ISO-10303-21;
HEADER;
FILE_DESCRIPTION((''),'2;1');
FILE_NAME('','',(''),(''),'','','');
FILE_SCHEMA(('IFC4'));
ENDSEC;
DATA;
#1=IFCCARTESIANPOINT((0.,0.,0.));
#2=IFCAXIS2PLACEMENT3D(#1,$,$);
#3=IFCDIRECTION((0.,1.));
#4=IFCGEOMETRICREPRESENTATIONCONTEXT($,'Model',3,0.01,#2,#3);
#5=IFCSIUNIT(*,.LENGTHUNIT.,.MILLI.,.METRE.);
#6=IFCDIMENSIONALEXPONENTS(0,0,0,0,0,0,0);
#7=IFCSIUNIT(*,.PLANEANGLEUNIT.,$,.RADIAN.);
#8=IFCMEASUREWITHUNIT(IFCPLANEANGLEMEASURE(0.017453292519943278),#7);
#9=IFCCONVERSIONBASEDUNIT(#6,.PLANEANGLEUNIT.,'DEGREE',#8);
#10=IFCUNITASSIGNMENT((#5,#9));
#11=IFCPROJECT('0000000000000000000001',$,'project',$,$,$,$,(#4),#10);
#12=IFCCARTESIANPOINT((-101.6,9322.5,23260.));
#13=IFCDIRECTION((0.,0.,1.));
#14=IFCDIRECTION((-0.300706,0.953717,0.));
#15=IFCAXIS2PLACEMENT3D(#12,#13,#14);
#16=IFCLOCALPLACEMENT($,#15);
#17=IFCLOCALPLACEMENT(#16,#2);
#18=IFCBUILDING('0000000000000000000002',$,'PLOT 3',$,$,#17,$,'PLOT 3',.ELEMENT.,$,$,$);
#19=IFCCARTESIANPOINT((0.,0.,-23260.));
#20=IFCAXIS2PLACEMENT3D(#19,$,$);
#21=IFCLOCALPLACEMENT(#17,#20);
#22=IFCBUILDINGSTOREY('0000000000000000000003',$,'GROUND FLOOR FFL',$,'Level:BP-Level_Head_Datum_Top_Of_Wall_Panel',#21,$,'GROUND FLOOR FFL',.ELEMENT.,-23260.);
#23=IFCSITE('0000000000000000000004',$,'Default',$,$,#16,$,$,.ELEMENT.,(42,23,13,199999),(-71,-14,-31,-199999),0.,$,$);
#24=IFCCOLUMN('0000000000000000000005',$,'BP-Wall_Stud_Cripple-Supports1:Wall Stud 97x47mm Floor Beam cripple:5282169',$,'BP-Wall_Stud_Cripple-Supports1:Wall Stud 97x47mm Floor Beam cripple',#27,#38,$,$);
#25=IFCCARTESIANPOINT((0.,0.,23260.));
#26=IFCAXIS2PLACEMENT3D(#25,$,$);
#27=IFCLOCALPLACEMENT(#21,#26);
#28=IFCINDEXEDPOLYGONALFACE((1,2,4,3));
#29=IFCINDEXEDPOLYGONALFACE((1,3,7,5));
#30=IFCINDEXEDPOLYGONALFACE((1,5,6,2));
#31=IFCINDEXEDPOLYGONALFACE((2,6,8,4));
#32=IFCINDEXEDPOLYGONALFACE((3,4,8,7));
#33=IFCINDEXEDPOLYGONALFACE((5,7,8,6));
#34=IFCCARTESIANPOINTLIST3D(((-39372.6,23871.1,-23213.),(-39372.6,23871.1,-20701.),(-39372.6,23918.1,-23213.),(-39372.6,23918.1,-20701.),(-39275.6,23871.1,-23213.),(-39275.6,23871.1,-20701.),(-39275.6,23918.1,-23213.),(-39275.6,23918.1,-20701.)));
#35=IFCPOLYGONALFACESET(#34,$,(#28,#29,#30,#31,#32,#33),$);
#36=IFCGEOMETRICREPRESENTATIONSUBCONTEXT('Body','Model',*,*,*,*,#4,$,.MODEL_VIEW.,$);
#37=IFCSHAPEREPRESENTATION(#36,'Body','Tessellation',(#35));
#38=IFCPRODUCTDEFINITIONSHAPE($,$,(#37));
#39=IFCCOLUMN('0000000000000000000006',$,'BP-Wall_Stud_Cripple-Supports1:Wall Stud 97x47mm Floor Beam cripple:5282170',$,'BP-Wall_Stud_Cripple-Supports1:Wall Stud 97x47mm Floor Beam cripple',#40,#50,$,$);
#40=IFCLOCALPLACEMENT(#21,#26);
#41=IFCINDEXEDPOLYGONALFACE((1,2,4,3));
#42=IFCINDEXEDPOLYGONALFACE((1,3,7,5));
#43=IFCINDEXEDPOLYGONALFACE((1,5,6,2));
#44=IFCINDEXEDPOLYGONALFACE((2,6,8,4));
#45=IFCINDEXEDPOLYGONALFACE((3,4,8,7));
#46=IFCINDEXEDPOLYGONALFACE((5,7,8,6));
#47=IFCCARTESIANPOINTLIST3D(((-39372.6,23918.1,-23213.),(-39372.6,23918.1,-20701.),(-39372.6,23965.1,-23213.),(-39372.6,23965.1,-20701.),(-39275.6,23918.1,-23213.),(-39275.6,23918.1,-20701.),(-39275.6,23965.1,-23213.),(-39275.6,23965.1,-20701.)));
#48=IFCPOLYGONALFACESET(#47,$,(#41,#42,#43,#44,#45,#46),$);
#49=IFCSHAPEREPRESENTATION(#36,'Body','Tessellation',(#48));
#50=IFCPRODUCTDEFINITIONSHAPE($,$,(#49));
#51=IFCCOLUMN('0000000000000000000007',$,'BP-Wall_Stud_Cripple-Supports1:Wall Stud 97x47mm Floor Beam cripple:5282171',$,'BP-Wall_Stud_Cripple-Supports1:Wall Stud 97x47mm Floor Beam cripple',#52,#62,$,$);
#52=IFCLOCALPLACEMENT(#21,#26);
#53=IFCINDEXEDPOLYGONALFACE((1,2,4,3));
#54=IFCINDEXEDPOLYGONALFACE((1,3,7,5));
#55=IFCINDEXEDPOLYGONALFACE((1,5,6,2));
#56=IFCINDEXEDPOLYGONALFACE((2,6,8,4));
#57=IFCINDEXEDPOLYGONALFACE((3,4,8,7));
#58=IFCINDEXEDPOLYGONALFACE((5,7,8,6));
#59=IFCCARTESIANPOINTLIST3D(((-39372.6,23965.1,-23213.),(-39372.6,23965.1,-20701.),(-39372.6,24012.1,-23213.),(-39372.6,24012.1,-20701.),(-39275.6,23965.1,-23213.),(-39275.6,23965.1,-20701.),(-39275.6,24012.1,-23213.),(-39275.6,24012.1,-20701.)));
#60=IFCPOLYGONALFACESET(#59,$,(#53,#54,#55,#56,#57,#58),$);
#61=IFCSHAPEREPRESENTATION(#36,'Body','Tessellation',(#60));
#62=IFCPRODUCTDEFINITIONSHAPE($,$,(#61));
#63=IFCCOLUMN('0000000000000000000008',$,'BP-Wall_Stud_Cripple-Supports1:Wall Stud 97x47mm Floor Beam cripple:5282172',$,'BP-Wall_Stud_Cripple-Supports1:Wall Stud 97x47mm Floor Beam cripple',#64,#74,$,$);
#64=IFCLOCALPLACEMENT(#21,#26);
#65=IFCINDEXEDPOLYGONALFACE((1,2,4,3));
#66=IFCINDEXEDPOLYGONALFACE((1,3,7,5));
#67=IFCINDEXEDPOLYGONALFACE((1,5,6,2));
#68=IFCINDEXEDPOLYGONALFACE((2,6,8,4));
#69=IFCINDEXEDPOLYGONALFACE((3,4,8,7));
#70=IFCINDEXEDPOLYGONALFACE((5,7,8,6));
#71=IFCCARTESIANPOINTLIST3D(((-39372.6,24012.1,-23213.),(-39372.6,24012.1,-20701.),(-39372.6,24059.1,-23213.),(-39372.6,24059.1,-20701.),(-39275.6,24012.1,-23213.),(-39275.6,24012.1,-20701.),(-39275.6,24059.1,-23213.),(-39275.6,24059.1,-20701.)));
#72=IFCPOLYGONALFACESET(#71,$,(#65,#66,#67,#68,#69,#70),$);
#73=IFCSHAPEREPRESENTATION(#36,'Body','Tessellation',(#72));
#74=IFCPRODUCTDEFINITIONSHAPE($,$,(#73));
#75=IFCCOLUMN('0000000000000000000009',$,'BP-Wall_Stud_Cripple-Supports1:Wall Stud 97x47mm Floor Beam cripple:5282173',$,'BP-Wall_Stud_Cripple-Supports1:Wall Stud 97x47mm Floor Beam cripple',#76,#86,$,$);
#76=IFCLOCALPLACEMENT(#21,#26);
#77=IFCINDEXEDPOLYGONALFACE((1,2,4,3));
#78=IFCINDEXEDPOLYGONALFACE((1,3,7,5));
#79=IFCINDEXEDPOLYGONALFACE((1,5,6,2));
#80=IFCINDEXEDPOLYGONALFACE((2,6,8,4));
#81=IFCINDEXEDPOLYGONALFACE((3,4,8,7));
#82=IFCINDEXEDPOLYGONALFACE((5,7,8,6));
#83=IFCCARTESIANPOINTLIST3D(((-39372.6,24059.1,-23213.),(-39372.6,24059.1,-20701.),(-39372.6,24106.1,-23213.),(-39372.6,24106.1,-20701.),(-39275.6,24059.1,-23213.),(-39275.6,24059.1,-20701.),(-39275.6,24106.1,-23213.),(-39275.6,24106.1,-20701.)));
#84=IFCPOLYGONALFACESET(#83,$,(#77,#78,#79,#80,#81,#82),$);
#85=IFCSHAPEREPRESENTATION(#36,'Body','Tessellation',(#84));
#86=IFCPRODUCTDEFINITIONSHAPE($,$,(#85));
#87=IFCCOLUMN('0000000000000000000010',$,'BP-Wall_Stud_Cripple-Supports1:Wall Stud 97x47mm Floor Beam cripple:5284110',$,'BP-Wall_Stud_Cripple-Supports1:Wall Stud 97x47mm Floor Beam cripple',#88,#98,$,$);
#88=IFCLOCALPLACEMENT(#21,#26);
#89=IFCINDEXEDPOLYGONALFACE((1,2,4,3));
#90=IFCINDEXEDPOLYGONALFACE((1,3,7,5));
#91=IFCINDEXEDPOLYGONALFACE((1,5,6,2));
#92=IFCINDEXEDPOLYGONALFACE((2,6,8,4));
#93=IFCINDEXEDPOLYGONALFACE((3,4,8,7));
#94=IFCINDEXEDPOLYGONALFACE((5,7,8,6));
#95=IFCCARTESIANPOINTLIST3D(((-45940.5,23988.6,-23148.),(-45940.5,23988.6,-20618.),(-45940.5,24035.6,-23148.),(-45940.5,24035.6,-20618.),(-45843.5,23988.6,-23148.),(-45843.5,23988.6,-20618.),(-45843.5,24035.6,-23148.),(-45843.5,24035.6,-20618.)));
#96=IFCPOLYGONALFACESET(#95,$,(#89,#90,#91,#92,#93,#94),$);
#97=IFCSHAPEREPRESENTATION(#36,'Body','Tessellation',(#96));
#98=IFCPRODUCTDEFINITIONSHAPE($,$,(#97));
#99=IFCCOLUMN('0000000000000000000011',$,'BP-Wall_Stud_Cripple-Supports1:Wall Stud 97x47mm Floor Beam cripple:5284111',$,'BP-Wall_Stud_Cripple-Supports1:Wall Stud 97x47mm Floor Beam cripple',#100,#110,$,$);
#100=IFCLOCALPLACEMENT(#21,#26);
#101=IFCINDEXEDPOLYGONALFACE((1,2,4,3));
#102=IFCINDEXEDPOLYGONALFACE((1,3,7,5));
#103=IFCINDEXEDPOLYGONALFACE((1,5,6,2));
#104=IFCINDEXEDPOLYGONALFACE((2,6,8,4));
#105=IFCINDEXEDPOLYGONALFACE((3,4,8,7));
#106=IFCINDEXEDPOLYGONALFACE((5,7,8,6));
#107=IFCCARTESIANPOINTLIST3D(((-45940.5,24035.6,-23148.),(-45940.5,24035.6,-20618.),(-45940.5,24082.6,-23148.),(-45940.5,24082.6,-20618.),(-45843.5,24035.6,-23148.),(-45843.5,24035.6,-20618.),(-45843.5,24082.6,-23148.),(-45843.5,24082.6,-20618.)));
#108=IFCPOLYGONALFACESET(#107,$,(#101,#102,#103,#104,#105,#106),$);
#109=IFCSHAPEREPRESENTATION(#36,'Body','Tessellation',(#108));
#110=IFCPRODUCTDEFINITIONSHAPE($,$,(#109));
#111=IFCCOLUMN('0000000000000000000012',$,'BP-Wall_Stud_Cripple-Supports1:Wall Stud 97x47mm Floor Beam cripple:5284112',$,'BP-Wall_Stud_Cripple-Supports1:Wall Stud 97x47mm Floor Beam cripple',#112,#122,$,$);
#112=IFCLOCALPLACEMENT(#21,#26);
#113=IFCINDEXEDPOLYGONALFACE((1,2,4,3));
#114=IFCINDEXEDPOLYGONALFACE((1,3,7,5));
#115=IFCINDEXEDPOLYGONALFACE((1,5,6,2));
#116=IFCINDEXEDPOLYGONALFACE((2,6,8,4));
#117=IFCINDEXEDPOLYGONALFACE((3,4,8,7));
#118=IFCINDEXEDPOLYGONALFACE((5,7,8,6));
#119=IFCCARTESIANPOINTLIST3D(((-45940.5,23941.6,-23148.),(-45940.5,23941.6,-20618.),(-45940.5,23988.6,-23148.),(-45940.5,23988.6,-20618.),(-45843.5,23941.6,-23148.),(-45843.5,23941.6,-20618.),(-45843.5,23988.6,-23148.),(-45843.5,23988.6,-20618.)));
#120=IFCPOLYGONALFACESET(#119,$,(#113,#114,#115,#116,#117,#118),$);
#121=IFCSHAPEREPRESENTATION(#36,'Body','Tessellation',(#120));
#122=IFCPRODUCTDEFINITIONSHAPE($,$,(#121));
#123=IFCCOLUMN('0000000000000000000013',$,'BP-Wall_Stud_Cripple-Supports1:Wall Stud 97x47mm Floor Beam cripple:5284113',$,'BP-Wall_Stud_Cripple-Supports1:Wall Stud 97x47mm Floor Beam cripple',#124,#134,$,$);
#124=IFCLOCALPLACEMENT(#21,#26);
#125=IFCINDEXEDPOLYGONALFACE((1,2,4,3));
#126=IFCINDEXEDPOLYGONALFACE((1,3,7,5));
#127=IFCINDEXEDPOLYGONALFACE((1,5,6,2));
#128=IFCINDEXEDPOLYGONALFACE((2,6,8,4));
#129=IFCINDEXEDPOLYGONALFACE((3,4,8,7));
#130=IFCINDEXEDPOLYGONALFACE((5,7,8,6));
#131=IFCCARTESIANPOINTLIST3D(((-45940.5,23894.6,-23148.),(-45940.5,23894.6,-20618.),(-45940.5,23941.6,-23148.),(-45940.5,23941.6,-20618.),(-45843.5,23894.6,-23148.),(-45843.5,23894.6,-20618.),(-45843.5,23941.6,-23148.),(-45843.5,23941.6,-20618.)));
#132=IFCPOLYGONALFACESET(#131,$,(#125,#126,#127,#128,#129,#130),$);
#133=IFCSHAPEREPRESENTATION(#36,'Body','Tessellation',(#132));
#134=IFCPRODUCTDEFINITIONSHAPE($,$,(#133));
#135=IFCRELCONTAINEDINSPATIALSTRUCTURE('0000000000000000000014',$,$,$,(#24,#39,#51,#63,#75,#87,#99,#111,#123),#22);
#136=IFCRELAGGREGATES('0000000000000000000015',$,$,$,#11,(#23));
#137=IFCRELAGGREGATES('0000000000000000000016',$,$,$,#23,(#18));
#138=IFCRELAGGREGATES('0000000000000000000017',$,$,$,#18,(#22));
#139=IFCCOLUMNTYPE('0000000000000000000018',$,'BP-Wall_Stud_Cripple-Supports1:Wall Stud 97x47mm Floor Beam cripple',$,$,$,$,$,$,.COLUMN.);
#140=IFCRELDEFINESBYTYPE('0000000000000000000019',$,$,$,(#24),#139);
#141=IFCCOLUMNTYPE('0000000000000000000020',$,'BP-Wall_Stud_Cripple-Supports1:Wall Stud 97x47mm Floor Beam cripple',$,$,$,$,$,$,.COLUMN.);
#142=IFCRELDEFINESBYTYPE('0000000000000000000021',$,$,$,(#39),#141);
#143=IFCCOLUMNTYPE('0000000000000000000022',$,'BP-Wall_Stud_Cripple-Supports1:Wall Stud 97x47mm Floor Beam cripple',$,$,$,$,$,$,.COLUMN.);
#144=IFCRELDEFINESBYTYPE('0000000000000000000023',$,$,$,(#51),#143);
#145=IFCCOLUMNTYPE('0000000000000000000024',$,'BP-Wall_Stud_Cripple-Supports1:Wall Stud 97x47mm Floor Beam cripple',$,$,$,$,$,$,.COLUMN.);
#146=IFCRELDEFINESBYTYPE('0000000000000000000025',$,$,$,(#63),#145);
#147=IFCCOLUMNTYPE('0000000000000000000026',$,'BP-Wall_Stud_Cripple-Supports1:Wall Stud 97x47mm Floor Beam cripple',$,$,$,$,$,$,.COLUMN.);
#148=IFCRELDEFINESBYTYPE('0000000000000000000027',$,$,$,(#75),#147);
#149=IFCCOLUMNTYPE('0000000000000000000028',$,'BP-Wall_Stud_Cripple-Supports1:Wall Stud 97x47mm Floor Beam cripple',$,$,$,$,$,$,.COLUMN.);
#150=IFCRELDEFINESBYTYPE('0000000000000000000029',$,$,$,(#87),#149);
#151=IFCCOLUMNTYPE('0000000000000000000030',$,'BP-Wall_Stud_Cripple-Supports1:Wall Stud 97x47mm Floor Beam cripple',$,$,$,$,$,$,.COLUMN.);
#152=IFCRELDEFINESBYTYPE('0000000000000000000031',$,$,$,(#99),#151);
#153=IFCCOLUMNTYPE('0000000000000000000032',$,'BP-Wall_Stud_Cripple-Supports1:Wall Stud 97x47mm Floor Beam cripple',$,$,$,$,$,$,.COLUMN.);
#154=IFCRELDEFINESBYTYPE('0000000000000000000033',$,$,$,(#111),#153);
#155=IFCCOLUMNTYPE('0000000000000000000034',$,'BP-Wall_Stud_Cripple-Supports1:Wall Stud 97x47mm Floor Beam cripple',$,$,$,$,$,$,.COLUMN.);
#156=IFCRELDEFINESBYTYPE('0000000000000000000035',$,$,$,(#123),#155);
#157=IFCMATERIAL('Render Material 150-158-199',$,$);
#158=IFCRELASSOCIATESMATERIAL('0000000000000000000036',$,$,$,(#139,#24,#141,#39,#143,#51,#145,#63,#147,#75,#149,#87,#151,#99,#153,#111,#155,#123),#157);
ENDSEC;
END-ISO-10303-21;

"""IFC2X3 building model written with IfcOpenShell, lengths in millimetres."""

from ifc_helpers import new_model, entity, si_unit, converted_unit, direction, frame, frame_2d, origin, place, context, subcontext, project, spatial, rectangle, extrude, source, transform, mapped, material, type_object, type_shapes, element, save


model = new_model("IFC2X3")

# Units and contexts
model_context = context("Model", 3, precision=0.01, world=origin(), true_north=direction((0.0, 1.0)))
body_context = subcontext(model_context, "Body", "Model", "MODEL_VIEW")
ifc_project = project(units=[si_unit("LENGTHUNIT", "METRE", prefix="MILLI"), converted_unit("PLANEANGLEUNIT", "DEGREE", entity("IfcPlaneAngleMeasure", 0.017453292519943278), si_unit("PLANEANGLEUNIT", "RADIAN"), dimensions=[0, 0, 0, 0, 0, 0, 0])], contexts=[model_context])

# Site, building, storey
site_placement = place(None, frame((-101.6, 9322.5, 23260.0), z_axis=(0.0, 0.0, 1.0), x_axis=(-0.300706, 0.953717, 0.0)))
site = spatial("IfcSite", under=ifc_project, at=site_placement, Name="Default", CompositionType="ELEMENT", RefLatitude=(42, 23, 13, 199999), RefLongitude=(-71, -14, -31, -199999), RefElevation=0.0)
building_placement = place(site_placement, origin())
building = spatial("IfcBuilding", under=site, at=building_placement, Name="PLOT 3", LongName="PLOT 3", CompositionType="ELEMENT")
storey_placement = place(building_placement, frame((0.0, 0.0, -23260.0)))
storey = spatial("IfcBuildingStorey", under=building, at=storey_placement, Name="GROUND FLOOR FFL", ObjectType="Level:BP-Level_Head_Datum_Top_Of_Wall_Panel", LongName="GROUND FLOOR FFL", CompositionType="ELEMENT", Elevation=-23260.0)

# Columns
ifc_material_1 = material(Name="Render Material 150-158-199")
column_type_1 = type_object("IfcColumnType", Name="BP-Wall_Stud_Cripple-Supports1:Wall Stud 97x47mm Floor Beam cripple", PredefinedType="COLUMN", material=ifc_material_1)
shared_shape_1 = source(origin(), body_context, "Body", "SweptSolid", [
    extrude(rectangle(XDim=97.0, YDim=47.0, at=frame_2d((0.0, 0.0), x_axis=(1.0, 0.0))), frame((-39324.1, 23894.6, -23213.0)), (0.0, 0.0, 1.0), 2512.0),
])
type_shapes(column_type_1, [shared_shape_1])
column_1_placement = place(storey_placement, frame((0.0, 0.0, 23260.0)))
element("IfcColumn", 1, at=column_1_placement, inside=storey, type_object=column_type_1, material=ifc_material_1, Name="BP-Wall_Stud_Cripple-Supports1:Wall Stud 97x47mm Floor Beam cripple:5282169", ObjectType="BP-Wall_Stud_Cripple-Supports1:Wall Stud 97x47mm Floor Beam cripple", context=body_context, shape_type="MappedRepresentation", body=[
    mapped(shared_shape_1, transform((0.0, 0.0, 0.0), scale=1.0)),
])
column_type_2 = type_object("IfcColumnType", Name="BP-Wall_Stud_Cripple-Supports1:Wall Stud 97x47mm Floor Beam cripple", PredefinedType="COLUMN", material=ifc_material_1)
shared_shape_2 = source(origin(), body_context, "Body", "SweptSolid", [
    extrude(rectangle(XDim=97.0, YDim=47.0, at=frame_2d((0.0, 0.0), x_axis=(1.0, 0.0))), frame((-39324.1, 23941.6, -23213.0)), (0.0, 0.0, 1.0), 2512.0),
])
type_shapes(column_type_2, [shared_shape_2])
column_2_placement = place(storey_placement, frame((0.0, 0.0, 23260.0)))
element("IfcColumn", 2, at=column_2_placement, inside=storey, type_object=column_type_2, material=ifc_material_1, Name="BP-Wall_Stud_Cripple-Supports1:Wall Stud 97x47mm Floor Beam cripple:5282170", ObjectType="BP-Wall_Stud_Cripple-Supports1:Wall Stud 97x47mm Floor Beam cripple", context=body_context, shape_type="MappedRepresentation", body=[
    mapped(shared_shape_2, transform((0.0, 0.0, 0.0), scale=1.0)),
])
column_type_3 = type_object("IfcColumnType", Name="BP-Wall_Stud_Cripple-Supports1:Wall Stud 97x47mm Floor Beam cripple", PredefinedType="COLUMN", material=ifc_material_1)
shared_shape_3 = source(origin(), body_context, "Body", "SweptSolid", [
    extrude(rectangle(XDim=97.0, YDim=47.0, at=frame_2d((0.0, 0.0), x_axis=(1.0, 0.0))), frame((-39324.1, 23988.6, -23213.0)), (0.0, 0.0, 1.0), 2512.0),
])
type_shapes(column_type_3, [shared_shape_3])
column_3_placement = place(storey_placement, frame((0.0, 0.0, 23260.0)))
element("IfcColumn", 3, at=column_3_placement, inside=storey, type_object=column_type_3, material=ifc_material_1, Name="BP-Wall_Stud_Cripple-Supports1:Wall Stud 97x47mm Floor Beam cripple:5282171", ObjectType="BP-Wall_Stud_Cripple-Supports1:Wall Stud 97x47mm Floor Beam cripple", context=body_context, shape_type="MappedRepresentation", body=[
    mapped(shared_shape_3, transform((0.0, 0.0, 0.0), scale=1.0)),
])
column_type_4 = type_object("IfcColumnType", Name="BP-Wall_Stud_Cripple-Supports1:Wall Stud 97x47mm Floor Beam cripple", PredefinedType="COLUMN", material=ifc_material_1)
shared_shape_4 = source(origin(), body_context, "Body", "SweptSolid", [
    extrude(rectangle(XDim=97.0, YDim=47.0, at=frame_2d((0.0, 0.0), x_axis=(1.0, 0.0))), frame((-39324.1, 24035.6, -23213.0)), (0.0, 0.0, 1.0), 2512.0),
])
type_shapes(column_type_4, [shared_shape_4])
column_4_placement = place(storey_placement, frame((0.0, 0.0, 23260.0)))
element("IfcColumn", 4, at=column_4_placement, inside=storey, type_object=column_type_4, material=ifc_material_1, Name="BP-Wall_Stud_Cripple-Supports1:Wall Stud 97x47mm Floor Beam cripple:5282172", ObjectType="BP-Wall_Stud_Cripple-Supports1:Wall Stud 97x47mm Floor Beam cripple", context=body_context, shape_type="MappedRepresentation", body=[
    mapped(shared_shape_4, transform((0.0, 0.0, 0.0), scale=1.0)),
])
column_type_5 = type_object("IfcColumnType", Name="BP-Wall_Stud_Cripple-Supports1:Wall Stud 97x47mm Floor Beam cripple", PredefinedType="COLUMN", material=ifc_material_1)
shared_shape_5 = source(origin(), body_context, "Body", "SweptSolid", [
    extrude(rectangle(XDim=97.0, YDim=47.0, at=frame_2d((0.0, 0.0), x_axis=(1.0, 0.0))), frame((-39324.1, 24082.6, -23213.0)), (0.0, 0.0, 1.0), 2512.0),
])
type_shapes(column_type_5, [shared_shape_5])
column_5_placement = place(storey_placement, frame((0.0, 0.0, 23260.0)))
element("IfcColumn", 5, at=column_5_placement, inside=storey, type_object=column_type_5, material=ifc_material_1, Name="BP-Wall_Stud_Cripple-Supports1:Wall Stud 97x47mm Floor Beam cripple:5282173", ObjectType="BP-Wall_Stud_Cripple-Supports1:Wall Stud 97x47mm Floor Beam cripple", context=body_context, shape_type="MappedRepresentation", body=[
    mapped(shared_shape_5, transform((0.0, 0.0, 0.0), scale=1.0)),
])
column_type_6 = type_object("IfcColumnType", Name="BP-Wall_Stud_Cripple-Supports1:Wall Stud 97x47mm Floor Beam cripple", PredefinedType="COLUMN", material=ifc_material_1)
shared_shape_6 = source(origin(), body_context, "Body", "SweptSolid", [
    extrude(rectangle(XDim=47.0, YDim=97.0, at=frame_2d((0.0, 0.0), x_axis=(1.0, 0.0))), frame((-45892.0, 24012.1, -23148.0), z_axis=(0.0, 0.0, 1.0), x_axis=(0.0, 1.0, 0.0)), (0.0, 0.0, 1.0), 2530.0),
])
type_shapes(column_type_6, [shared_shape_6])
column_6_placement = place(storey_placement, frame((0.0, 0.0, 23260.0)))
element("IfcColumn", 6, at=column_6_placement, inside=storey, type_object=column_type_6, material=ifc_material_1, Name="BP-Wall_Stud_Cripple-Supports1:Wall Stud 97x47mm Floor Beam cripple:5284110", ObjectType="BP-Wall_Stud_Cripple-Supports1:Wall Stud 97x47mm Floor Beam cripple", context=body_context, shape_type="MappedRepresentation", body=[
    mapped(shared_shape_6, transform((0.0, 0.0, 0.0), scale=1.0)),
])
column_type_7 = type_object("IfcColumnType", Name="BP-Wall_Stud_Cripple-Supports1:Wall Stud 97x47mm Floor Beam cripple", PredefinedType="COLUMN", material=ifc_material_1)
shared_shape_7 = source(origin(), body_context, "Body", "SweptSolid", [
    extrude(rectangle(XDim=47.0, YDim=97.0, at=frame_2d((0.0, 0.0), x_axis=(1.0, 0.0))), frame((-45892.0, 24059.1, -23148.0), z_axis=(0.0, 0.0, 1.0), x_axis=(0.0, 1.0, 0.0)), (0.0, 0.0, 1.0), 2530.0),
])
type_shapes(column_type_7, [shared_shape_7])
column_7_placement = place(storey_placement, frame((0.0, 0.0, 23260.0)))
element("IfcColumn", 7, at=column_7_placement, inside=storey, type_object=column_type_7, material=ifc_material_1, Name="BP-Wall_Stud_Cripple-Supports1:Wall Stud 97x47mm Floor Beam cripple:5284111", ObjectType="BP-Wall_Stud_Cripple-Supports1:Wall Stud 97x47mm Floor Beam cripple", context=body_context, shape_type="MappedRepresentation", body=[
    mapped(shared_shape_7, transform((0.0, 0.0, 0.0), scale=1.0)),
])
column_type_8 = type_object("IfcColumnType", Name="BP-Wall_Stud_Cripple-Supports1:Wall Stud 97x47mm Floor Beam cripple", PredefinedType="COLUMN", material=ifc_material_1)
shared_shape_8 = source(origin(), body_context, "Body", "SweptSolid", [
    extrude(rectangle(XDim=47.0, YDim=97.0, at=frame_2d((0.0, 0.0), x_axis=(1.0, 0.0))), frame((-45892.0, 23965.1, -23148.0), z_axis=(0.0, 0.0, 1.0), x_axis=(0.0, 1.0, 0.0)), (0.0, 0.0, 1.0), 2530.0),
])
type_shapes(column_type_8, [shared_shape_8])
column_8_placement = place(storey_placement, frame((0.0, 0.0, 23260.0)))
element("IfcColumn", 8, at=column_8_placement, inside=storey, type_object=column_type_8, material=ifc_material_1, Name="BP-Wall_Stud_Cripple-Supports1:Wall Stud 97x47mm Floor Beam cripple:5284112", ObjectType="BP-Wall_Stud_Cripple-Supports1:Wall Stud 97x47mm Floor Beam cripple", context=body_context, shape_type="MappedRepresentation", body=[
    mapped(shared_shape_8, transform((0.0, 0.0, 0.0), scale=1.0)),
])
column_type_9 = type_object("IfcColumnType", Name="BP-Wall_Stud_Cripple-Supports1:Wall Stud 97x47mm Floor Beam cripple", PredefinedType="COLUMN", material=ifc_material_1)
shared_shape_9 = source(origin(), body_context, "Body", "SweptSolid", [
    extrude(rectangle(XDim=47.0, YDim=97.0, at=frame_2d((0.0, 0.0), x_axis=(1.0, 0.0))), frame((-45892.0, 23918.1, -23148.0), z_axis=(0.0, 0.0, 1.0), x_axis=(0.0, 1.0, 0.0)), (0.0, 0.0, 1.0), 2530.0),
])
type_shapes(column_type_9, [shared_shape_9])
column_9_placement = place(storey_placement, frame((0.0, 0.0, 23260.0)))
element("IfcColumn", 9, at=column_9_placement, inside=storey, type_object=column_type_9, material=ifc_material_1, Name="BP-Wall_Stud_Cripple-Supports1:Wall Stud 97x47mm Floor Beam cripple:5284113", ObjectType="BP-Wall_Stud_Cripple-Supports1:Wall Stud 97x47mm Floor Beam cripple", context=body_context, shape_type="MappedRepresentation", body=[
    mapped(shared_shape_9, transform((0.0, 0.0, 0.0), scale=1.0)),
])

save(model, "model.ifc")
